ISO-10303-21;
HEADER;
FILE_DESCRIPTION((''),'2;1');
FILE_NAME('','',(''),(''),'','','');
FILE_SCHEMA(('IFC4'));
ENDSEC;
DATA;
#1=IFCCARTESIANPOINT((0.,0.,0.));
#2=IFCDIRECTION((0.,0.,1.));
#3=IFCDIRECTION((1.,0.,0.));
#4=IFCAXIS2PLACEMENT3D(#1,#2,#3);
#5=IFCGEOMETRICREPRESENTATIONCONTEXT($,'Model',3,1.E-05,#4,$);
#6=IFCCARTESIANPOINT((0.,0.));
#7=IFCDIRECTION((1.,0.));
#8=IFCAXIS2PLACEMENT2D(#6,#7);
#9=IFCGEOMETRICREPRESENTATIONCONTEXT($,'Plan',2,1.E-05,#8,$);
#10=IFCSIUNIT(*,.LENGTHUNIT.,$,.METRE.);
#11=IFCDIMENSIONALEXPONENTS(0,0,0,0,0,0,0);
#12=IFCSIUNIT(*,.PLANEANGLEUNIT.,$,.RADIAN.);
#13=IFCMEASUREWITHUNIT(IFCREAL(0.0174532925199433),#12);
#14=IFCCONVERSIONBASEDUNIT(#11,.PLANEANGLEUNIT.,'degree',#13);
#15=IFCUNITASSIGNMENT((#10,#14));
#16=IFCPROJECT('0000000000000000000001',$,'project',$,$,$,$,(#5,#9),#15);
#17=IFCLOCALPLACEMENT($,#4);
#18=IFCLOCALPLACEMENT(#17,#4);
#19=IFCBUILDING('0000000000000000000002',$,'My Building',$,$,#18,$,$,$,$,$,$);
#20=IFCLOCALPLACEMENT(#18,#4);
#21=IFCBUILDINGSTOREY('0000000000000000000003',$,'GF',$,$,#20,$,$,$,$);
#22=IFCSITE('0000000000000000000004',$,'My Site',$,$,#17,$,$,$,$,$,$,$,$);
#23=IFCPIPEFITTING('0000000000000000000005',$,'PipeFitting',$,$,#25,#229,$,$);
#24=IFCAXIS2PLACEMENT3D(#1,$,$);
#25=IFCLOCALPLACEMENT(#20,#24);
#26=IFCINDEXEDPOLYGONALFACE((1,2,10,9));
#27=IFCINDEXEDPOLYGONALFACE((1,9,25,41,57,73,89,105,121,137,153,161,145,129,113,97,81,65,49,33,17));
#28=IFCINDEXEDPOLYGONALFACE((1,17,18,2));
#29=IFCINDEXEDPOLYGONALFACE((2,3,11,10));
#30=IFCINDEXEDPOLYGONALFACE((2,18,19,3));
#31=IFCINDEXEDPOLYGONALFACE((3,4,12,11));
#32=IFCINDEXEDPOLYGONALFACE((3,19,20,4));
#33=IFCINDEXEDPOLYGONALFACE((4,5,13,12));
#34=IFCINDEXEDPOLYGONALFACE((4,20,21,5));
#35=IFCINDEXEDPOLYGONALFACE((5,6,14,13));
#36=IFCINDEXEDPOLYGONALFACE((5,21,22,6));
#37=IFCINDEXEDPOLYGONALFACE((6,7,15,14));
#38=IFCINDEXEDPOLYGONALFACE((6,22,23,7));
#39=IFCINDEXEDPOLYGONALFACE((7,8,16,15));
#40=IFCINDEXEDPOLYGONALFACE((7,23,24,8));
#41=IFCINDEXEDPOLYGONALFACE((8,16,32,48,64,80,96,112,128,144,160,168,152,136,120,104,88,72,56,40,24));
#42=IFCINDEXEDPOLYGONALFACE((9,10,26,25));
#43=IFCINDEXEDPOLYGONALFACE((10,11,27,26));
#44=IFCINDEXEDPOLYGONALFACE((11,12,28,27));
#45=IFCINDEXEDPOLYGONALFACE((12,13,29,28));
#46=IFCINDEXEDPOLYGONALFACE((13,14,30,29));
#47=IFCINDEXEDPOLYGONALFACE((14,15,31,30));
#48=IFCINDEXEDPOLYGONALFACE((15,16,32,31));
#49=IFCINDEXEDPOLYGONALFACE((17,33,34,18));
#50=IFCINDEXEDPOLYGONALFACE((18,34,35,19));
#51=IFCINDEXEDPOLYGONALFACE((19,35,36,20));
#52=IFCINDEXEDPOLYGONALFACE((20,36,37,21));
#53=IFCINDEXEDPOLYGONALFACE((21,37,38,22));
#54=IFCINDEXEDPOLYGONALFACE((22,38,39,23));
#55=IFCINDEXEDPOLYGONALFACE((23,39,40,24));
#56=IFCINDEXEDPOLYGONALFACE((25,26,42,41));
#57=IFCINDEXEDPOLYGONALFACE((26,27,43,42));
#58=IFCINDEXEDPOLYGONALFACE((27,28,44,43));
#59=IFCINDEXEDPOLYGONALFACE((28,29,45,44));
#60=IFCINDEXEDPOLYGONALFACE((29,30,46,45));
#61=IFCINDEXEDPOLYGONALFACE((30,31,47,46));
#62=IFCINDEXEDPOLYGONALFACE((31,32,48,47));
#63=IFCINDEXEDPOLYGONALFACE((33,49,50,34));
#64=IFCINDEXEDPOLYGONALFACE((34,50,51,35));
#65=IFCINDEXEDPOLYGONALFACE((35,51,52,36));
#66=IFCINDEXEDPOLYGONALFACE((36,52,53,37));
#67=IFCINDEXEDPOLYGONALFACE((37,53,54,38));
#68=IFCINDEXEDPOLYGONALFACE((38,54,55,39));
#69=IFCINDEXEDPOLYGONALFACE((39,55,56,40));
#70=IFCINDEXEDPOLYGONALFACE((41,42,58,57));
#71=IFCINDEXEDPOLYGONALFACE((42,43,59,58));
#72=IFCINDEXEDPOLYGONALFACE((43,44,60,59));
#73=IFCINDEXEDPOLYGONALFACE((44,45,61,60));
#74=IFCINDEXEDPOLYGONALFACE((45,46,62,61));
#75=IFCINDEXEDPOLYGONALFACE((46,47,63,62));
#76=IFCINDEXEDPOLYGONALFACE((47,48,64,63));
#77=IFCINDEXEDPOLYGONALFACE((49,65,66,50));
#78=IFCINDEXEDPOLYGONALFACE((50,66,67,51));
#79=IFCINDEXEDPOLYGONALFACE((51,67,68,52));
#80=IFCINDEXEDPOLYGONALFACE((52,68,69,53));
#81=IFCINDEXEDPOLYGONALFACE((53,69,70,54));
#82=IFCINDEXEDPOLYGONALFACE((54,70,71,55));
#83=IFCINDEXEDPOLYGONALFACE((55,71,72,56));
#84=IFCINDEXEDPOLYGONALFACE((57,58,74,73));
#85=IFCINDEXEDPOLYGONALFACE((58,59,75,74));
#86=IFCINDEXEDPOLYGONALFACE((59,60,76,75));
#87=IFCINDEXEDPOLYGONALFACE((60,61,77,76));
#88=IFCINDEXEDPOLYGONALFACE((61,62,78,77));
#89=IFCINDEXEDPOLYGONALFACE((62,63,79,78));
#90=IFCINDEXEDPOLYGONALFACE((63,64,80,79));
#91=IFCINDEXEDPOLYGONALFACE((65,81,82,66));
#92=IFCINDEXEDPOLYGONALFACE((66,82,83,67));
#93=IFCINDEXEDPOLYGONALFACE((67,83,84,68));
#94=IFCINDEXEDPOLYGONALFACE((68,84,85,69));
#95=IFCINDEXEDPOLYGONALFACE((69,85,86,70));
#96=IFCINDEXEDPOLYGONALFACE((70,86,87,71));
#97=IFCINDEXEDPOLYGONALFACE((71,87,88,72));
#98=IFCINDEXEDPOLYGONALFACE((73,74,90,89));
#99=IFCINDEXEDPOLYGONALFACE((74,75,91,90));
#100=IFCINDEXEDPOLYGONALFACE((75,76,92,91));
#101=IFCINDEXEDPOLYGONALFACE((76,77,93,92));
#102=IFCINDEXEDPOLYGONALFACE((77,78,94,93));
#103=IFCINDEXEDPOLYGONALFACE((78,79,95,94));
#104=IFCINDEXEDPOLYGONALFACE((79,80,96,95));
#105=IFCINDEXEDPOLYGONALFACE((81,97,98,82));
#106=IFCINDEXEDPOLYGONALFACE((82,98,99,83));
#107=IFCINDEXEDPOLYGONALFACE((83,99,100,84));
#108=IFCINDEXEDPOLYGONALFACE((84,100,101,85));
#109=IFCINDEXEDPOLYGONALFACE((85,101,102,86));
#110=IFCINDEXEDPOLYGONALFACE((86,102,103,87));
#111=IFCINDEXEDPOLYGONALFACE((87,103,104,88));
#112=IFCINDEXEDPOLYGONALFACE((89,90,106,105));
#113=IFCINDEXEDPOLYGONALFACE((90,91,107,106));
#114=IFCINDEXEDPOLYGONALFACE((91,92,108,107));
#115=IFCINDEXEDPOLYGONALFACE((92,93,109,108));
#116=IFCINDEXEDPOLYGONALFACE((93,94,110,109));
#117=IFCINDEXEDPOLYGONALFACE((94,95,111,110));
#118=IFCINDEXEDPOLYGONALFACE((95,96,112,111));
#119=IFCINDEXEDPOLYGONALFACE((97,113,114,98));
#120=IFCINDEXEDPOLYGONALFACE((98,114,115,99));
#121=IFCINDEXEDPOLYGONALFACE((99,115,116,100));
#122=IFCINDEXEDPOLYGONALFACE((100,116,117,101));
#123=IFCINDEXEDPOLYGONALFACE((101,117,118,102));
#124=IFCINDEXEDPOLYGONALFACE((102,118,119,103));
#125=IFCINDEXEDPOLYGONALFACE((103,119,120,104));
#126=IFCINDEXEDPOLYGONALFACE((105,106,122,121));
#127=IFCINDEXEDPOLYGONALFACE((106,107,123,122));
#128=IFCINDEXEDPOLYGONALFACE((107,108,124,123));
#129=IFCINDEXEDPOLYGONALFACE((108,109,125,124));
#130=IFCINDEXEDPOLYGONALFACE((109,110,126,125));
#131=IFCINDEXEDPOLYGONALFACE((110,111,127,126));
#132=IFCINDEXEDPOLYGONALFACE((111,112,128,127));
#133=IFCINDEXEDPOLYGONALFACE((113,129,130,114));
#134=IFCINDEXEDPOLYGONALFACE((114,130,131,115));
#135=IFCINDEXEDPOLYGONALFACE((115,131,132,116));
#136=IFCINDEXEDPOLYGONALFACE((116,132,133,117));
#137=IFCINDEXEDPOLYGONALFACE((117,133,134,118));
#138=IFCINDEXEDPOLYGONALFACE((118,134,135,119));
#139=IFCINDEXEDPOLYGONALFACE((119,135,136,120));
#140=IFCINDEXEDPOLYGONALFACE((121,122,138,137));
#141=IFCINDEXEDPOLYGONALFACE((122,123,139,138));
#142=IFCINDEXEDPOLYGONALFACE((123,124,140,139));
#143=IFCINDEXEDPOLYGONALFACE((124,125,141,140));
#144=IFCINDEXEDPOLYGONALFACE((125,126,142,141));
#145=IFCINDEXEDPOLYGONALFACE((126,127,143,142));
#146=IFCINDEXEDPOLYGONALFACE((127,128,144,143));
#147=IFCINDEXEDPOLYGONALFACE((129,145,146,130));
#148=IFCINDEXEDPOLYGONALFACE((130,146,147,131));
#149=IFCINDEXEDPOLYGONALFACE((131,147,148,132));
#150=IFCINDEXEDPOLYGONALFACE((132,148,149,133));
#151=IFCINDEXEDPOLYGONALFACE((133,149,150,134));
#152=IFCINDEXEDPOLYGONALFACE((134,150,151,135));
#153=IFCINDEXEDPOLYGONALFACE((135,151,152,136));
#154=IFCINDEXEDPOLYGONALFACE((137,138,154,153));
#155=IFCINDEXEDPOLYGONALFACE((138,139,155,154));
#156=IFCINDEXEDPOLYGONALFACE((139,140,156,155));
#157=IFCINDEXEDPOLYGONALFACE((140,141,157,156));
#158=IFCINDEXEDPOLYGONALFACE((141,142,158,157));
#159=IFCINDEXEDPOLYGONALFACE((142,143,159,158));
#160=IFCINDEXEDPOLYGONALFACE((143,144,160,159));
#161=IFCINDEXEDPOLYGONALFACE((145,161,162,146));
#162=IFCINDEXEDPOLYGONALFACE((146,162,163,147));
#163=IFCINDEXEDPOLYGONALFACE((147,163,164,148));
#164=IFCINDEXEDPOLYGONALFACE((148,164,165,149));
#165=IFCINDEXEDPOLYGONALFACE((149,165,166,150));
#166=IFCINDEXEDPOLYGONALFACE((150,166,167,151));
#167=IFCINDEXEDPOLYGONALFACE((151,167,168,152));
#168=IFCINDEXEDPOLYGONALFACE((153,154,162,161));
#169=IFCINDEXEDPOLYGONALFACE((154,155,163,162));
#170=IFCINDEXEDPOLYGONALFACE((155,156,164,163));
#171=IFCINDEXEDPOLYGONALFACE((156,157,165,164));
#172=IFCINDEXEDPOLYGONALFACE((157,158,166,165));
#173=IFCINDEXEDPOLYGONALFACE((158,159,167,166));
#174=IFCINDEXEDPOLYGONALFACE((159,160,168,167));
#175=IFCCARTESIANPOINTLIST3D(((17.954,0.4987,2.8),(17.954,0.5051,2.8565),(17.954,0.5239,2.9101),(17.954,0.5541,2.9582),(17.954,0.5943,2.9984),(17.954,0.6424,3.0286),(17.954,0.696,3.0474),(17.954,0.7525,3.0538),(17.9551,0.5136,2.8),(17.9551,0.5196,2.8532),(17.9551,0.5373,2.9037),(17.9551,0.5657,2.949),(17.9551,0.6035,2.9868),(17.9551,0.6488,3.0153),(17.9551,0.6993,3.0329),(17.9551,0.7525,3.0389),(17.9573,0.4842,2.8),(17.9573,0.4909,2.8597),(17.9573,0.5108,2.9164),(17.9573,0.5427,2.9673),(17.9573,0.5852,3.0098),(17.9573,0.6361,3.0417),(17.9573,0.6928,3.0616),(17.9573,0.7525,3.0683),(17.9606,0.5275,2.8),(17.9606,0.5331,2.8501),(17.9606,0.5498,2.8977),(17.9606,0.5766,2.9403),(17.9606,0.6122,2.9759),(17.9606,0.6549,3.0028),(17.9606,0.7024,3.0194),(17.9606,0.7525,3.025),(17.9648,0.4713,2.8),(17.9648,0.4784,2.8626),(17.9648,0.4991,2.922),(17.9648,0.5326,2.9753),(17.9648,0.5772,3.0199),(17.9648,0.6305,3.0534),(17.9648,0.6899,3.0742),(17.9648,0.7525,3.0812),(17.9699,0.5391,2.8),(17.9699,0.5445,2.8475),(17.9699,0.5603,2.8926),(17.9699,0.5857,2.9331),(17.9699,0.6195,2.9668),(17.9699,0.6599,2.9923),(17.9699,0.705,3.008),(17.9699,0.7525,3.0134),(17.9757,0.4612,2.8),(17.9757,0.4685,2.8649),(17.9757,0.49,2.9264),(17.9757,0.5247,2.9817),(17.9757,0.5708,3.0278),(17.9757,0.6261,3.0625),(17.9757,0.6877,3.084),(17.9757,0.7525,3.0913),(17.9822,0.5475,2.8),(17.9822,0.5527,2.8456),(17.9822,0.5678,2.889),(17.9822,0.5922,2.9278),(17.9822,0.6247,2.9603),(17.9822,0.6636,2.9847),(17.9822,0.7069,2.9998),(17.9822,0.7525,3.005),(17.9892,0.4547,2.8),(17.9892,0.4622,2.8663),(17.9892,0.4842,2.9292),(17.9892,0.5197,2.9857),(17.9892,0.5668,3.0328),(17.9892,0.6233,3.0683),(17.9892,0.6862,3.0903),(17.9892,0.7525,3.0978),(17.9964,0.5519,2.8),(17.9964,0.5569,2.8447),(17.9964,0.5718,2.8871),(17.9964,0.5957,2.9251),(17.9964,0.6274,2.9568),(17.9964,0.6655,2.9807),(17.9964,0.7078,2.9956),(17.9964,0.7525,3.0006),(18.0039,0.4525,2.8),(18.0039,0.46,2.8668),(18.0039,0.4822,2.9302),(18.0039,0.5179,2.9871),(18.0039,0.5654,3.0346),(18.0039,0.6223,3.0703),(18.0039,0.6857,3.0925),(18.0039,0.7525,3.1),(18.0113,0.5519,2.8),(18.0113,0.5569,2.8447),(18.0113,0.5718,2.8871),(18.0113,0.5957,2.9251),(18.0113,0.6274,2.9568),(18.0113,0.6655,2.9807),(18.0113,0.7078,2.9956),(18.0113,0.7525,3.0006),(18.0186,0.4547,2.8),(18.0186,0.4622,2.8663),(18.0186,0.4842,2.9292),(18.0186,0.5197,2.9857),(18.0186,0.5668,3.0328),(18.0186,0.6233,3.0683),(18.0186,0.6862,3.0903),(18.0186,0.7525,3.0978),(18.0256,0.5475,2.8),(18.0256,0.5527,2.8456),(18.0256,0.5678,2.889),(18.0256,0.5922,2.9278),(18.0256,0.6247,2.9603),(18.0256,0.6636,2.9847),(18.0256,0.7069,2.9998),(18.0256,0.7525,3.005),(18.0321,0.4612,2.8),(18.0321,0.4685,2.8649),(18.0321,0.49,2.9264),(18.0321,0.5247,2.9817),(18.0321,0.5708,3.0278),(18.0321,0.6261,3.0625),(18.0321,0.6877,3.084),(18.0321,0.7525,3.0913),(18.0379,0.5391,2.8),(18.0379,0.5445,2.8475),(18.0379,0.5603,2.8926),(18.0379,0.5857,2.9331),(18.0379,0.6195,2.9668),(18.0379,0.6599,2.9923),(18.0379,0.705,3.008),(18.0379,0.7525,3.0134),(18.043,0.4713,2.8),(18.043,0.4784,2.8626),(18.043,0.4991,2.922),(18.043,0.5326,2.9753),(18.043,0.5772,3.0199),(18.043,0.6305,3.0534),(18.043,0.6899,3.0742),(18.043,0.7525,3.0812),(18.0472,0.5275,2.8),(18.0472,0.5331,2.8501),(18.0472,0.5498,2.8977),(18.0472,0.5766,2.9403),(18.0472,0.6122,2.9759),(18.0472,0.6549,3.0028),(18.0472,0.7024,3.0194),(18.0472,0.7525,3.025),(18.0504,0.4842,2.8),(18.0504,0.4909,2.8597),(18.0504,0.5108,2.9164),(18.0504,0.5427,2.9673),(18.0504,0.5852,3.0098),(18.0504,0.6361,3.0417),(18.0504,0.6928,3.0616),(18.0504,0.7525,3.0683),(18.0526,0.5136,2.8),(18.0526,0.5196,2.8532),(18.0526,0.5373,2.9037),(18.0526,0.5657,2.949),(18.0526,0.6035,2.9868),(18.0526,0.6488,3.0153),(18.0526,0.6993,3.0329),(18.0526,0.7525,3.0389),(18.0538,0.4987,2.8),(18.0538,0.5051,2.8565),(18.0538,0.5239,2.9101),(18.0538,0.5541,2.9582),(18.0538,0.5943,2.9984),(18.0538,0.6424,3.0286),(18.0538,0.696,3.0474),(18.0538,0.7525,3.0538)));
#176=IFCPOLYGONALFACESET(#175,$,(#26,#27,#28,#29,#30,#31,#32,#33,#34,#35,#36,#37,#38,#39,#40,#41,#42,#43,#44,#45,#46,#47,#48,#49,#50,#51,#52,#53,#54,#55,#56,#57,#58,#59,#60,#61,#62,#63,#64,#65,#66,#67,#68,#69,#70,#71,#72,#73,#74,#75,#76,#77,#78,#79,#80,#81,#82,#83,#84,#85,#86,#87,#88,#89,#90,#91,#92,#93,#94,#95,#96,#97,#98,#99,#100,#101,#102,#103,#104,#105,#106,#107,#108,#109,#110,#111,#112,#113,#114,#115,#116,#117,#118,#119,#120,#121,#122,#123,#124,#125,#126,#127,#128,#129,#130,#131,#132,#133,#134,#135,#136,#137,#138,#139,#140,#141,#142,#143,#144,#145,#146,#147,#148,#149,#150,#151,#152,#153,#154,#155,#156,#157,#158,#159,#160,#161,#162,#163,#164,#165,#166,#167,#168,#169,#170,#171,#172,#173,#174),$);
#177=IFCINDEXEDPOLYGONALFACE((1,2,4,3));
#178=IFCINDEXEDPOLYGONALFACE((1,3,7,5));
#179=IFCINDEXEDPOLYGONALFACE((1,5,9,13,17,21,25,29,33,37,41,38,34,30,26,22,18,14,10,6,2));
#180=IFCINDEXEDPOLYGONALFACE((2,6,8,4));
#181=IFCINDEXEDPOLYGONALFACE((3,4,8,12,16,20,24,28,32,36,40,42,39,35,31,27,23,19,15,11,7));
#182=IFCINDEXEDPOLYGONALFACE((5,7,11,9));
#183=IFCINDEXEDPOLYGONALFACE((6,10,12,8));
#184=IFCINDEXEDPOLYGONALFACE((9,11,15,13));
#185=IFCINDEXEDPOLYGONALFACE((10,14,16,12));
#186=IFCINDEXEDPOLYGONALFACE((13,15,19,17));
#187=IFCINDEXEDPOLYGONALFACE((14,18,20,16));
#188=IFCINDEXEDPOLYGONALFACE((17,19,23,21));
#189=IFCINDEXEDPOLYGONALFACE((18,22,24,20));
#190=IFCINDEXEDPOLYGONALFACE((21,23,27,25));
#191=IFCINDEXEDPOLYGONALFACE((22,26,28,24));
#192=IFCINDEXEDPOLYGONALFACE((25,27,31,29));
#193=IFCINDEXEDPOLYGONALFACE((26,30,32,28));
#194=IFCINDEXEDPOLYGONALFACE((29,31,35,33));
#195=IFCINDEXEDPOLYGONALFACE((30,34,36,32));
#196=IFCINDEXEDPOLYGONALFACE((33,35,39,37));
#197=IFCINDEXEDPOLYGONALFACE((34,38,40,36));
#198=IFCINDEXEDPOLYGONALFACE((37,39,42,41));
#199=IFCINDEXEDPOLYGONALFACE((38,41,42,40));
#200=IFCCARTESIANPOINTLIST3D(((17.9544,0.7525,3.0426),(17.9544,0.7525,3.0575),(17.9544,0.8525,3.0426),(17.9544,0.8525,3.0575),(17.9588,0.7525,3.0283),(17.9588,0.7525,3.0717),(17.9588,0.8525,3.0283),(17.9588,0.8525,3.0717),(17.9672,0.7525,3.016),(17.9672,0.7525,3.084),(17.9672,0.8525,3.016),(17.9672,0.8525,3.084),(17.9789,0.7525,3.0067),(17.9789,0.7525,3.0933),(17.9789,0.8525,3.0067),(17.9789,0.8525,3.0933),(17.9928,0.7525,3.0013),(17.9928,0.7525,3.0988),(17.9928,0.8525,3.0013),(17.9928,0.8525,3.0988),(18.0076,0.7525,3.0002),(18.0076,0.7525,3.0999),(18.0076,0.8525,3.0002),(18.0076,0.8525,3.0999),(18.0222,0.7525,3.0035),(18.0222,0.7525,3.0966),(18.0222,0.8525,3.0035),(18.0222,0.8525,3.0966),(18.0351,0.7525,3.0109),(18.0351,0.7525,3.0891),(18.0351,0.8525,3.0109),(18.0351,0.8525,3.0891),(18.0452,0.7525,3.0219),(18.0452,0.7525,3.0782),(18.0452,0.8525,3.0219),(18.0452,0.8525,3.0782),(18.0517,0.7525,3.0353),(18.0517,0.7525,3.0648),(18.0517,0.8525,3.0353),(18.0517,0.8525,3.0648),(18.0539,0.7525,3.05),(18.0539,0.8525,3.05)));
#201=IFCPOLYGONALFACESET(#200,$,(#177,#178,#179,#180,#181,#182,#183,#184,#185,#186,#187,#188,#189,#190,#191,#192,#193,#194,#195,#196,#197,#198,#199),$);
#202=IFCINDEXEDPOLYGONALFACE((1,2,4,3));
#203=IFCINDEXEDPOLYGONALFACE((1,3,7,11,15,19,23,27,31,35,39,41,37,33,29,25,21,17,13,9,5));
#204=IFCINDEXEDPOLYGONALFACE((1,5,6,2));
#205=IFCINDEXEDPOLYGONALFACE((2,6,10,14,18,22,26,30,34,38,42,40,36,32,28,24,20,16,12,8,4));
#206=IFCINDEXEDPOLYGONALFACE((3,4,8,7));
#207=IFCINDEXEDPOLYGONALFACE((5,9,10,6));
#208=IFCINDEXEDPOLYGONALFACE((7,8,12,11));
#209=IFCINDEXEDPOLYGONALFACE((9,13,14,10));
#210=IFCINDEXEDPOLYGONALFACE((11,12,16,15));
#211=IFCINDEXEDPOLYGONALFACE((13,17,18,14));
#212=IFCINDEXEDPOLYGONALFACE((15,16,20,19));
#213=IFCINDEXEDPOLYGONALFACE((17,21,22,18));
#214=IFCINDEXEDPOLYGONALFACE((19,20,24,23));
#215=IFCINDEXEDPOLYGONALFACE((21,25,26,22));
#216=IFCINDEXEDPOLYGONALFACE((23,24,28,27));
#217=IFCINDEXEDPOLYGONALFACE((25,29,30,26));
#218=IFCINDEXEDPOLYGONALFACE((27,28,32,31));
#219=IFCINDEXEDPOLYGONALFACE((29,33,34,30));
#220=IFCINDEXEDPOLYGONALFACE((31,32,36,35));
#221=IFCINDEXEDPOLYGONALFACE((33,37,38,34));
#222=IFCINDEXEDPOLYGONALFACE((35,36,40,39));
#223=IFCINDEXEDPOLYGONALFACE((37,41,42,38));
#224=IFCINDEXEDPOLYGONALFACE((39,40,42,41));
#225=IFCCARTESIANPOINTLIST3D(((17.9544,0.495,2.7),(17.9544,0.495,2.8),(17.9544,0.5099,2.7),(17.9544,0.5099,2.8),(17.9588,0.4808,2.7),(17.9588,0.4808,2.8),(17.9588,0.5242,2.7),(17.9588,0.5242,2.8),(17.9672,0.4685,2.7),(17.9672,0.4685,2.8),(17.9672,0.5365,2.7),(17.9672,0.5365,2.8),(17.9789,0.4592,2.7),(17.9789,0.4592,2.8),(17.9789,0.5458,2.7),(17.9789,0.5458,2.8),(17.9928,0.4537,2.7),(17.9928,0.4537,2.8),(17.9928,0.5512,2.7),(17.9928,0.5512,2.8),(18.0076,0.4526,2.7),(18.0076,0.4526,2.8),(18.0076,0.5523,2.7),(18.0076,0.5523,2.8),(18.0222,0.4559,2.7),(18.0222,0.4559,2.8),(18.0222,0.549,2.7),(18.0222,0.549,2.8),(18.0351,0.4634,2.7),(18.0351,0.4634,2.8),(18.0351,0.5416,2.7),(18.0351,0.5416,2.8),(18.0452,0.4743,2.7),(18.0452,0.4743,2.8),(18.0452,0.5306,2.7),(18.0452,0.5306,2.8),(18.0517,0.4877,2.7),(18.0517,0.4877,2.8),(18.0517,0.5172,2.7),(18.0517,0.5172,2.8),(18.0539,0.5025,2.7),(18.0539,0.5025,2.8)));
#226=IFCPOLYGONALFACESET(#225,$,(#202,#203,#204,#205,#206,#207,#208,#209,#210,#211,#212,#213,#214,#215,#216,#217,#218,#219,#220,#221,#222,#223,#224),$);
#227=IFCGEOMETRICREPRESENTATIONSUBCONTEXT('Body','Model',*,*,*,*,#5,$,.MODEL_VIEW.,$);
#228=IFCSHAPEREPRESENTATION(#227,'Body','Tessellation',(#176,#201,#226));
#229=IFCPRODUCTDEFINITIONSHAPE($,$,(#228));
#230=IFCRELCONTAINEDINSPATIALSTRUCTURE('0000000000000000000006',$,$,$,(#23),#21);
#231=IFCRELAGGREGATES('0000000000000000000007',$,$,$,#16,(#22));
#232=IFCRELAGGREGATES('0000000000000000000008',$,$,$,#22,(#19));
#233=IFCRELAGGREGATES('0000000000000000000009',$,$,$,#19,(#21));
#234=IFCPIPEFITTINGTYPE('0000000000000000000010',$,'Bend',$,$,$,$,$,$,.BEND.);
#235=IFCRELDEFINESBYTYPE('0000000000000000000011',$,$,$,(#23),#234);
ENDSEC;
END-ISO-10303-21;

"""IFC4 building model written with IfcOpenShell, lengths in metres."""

from ifc_helpers import new_model, entity, si_unit, converted_unit, frame, origin_with_axes, origin_2d_with_axis, place, context, subcontext, project, spatial, circle, extrude, source, transform, mapped, type_object, type_shapes, element, save


model = new_model("IFC4")

# Units and contexts
model_context = context("Model", 3, precision=1e-05, world=origin_with_axes())
plan_context = context("Plan", 2, precision=1e-05, world=origin_2d_with_axis())
body_context_1 = subcontext(model_context, "Body", "Model", "MODEL_VIEW")
ifc_project = project(units=[si_unit("LENGTHUNIT", "METRE"), converted_unit("PLANEANGLEUNIT", "degree", entity("IfcReal", 0.0174532925199433), si_unit("PLANEANGLEUNIT", "RADIAN"), dimensions=[0, 0, 0, 0, 0, 0, 0])], contexts=[model_context, plan_context])

# Site, building, storey
site_placement = place(None, origin_with_axes())
site = spatial("IfcSite", under=ifc_project, at=site_placement, Name="My Site")
building_placement = place(site_placement, origin_with_axes())
building = spatial("IfcBuilding", under=site, at=building_placement, Name="My Building")
storey_placement = place(building_placement, origin_with_axes())
storey = spatial("IfcBuildingStorey", under=building, at=storey_placement, Name="GF")

# Pipe fitting
pipe_fitting_type = type_object("IfcPipeFittingType", Name="Bend", PredefinedType="BEND")
shared_shape_1 = source(origin_with_axes(), body_context_1, "Body", "SolidModel", [
    entity("IfcSweptDiskSolid", entity("IfcIndexedPolyCurve", entity("IfcCartesianPointList3D", [[0.0, 0.0, 0.1], [0.0, -0.0732, 0.2768], [0.0, -0.25, 0.35]]), [entity("IfcArcIndex", [1, 2, 3])]), 0.05),
    extrude(circle(Radius=0.05), origin_with_axes(), (0.0, 0.0, 1.0), 0.1),
    extrude(circle(Radius=0.05), frame((0.0, -0.25, 0.35), z_axis=(0.0, -1.0, 0.0), x_axis=(1.0, 0.0, 0.0)), (0.0, 0.0, 1.0), 0.1),
])
type_shapes(pipe_fitting_type, [shared_shape_1])
for number, where, z_axis, x_axis, name in (
    (1, (18.0039, 0.8525, 3.05), (0.0, -1.0, 0.0), (1.0, 0.0, 0.0), "PipeFitting"),
):
    element("IfcPipeFitting", number, at=place(storey_placement, frame(where, z_axis=z_axis, x_axis=x_axis)), inside=storey, type_object=pipe_fitting_type, Name=name, context=body_context_1, shape_type="MappedRepresentation", body=[
        mapped(shared_shape_1, transform((0.0, 0.0, 0.0), x_axis=(1.0, 0.0, 0.0), y_axis=(0.0, 1.0, 0.0), z_axis=(0.0, 0.0, 1.0), scale=1.0)),
    ])

save(model, "model.ifc")
